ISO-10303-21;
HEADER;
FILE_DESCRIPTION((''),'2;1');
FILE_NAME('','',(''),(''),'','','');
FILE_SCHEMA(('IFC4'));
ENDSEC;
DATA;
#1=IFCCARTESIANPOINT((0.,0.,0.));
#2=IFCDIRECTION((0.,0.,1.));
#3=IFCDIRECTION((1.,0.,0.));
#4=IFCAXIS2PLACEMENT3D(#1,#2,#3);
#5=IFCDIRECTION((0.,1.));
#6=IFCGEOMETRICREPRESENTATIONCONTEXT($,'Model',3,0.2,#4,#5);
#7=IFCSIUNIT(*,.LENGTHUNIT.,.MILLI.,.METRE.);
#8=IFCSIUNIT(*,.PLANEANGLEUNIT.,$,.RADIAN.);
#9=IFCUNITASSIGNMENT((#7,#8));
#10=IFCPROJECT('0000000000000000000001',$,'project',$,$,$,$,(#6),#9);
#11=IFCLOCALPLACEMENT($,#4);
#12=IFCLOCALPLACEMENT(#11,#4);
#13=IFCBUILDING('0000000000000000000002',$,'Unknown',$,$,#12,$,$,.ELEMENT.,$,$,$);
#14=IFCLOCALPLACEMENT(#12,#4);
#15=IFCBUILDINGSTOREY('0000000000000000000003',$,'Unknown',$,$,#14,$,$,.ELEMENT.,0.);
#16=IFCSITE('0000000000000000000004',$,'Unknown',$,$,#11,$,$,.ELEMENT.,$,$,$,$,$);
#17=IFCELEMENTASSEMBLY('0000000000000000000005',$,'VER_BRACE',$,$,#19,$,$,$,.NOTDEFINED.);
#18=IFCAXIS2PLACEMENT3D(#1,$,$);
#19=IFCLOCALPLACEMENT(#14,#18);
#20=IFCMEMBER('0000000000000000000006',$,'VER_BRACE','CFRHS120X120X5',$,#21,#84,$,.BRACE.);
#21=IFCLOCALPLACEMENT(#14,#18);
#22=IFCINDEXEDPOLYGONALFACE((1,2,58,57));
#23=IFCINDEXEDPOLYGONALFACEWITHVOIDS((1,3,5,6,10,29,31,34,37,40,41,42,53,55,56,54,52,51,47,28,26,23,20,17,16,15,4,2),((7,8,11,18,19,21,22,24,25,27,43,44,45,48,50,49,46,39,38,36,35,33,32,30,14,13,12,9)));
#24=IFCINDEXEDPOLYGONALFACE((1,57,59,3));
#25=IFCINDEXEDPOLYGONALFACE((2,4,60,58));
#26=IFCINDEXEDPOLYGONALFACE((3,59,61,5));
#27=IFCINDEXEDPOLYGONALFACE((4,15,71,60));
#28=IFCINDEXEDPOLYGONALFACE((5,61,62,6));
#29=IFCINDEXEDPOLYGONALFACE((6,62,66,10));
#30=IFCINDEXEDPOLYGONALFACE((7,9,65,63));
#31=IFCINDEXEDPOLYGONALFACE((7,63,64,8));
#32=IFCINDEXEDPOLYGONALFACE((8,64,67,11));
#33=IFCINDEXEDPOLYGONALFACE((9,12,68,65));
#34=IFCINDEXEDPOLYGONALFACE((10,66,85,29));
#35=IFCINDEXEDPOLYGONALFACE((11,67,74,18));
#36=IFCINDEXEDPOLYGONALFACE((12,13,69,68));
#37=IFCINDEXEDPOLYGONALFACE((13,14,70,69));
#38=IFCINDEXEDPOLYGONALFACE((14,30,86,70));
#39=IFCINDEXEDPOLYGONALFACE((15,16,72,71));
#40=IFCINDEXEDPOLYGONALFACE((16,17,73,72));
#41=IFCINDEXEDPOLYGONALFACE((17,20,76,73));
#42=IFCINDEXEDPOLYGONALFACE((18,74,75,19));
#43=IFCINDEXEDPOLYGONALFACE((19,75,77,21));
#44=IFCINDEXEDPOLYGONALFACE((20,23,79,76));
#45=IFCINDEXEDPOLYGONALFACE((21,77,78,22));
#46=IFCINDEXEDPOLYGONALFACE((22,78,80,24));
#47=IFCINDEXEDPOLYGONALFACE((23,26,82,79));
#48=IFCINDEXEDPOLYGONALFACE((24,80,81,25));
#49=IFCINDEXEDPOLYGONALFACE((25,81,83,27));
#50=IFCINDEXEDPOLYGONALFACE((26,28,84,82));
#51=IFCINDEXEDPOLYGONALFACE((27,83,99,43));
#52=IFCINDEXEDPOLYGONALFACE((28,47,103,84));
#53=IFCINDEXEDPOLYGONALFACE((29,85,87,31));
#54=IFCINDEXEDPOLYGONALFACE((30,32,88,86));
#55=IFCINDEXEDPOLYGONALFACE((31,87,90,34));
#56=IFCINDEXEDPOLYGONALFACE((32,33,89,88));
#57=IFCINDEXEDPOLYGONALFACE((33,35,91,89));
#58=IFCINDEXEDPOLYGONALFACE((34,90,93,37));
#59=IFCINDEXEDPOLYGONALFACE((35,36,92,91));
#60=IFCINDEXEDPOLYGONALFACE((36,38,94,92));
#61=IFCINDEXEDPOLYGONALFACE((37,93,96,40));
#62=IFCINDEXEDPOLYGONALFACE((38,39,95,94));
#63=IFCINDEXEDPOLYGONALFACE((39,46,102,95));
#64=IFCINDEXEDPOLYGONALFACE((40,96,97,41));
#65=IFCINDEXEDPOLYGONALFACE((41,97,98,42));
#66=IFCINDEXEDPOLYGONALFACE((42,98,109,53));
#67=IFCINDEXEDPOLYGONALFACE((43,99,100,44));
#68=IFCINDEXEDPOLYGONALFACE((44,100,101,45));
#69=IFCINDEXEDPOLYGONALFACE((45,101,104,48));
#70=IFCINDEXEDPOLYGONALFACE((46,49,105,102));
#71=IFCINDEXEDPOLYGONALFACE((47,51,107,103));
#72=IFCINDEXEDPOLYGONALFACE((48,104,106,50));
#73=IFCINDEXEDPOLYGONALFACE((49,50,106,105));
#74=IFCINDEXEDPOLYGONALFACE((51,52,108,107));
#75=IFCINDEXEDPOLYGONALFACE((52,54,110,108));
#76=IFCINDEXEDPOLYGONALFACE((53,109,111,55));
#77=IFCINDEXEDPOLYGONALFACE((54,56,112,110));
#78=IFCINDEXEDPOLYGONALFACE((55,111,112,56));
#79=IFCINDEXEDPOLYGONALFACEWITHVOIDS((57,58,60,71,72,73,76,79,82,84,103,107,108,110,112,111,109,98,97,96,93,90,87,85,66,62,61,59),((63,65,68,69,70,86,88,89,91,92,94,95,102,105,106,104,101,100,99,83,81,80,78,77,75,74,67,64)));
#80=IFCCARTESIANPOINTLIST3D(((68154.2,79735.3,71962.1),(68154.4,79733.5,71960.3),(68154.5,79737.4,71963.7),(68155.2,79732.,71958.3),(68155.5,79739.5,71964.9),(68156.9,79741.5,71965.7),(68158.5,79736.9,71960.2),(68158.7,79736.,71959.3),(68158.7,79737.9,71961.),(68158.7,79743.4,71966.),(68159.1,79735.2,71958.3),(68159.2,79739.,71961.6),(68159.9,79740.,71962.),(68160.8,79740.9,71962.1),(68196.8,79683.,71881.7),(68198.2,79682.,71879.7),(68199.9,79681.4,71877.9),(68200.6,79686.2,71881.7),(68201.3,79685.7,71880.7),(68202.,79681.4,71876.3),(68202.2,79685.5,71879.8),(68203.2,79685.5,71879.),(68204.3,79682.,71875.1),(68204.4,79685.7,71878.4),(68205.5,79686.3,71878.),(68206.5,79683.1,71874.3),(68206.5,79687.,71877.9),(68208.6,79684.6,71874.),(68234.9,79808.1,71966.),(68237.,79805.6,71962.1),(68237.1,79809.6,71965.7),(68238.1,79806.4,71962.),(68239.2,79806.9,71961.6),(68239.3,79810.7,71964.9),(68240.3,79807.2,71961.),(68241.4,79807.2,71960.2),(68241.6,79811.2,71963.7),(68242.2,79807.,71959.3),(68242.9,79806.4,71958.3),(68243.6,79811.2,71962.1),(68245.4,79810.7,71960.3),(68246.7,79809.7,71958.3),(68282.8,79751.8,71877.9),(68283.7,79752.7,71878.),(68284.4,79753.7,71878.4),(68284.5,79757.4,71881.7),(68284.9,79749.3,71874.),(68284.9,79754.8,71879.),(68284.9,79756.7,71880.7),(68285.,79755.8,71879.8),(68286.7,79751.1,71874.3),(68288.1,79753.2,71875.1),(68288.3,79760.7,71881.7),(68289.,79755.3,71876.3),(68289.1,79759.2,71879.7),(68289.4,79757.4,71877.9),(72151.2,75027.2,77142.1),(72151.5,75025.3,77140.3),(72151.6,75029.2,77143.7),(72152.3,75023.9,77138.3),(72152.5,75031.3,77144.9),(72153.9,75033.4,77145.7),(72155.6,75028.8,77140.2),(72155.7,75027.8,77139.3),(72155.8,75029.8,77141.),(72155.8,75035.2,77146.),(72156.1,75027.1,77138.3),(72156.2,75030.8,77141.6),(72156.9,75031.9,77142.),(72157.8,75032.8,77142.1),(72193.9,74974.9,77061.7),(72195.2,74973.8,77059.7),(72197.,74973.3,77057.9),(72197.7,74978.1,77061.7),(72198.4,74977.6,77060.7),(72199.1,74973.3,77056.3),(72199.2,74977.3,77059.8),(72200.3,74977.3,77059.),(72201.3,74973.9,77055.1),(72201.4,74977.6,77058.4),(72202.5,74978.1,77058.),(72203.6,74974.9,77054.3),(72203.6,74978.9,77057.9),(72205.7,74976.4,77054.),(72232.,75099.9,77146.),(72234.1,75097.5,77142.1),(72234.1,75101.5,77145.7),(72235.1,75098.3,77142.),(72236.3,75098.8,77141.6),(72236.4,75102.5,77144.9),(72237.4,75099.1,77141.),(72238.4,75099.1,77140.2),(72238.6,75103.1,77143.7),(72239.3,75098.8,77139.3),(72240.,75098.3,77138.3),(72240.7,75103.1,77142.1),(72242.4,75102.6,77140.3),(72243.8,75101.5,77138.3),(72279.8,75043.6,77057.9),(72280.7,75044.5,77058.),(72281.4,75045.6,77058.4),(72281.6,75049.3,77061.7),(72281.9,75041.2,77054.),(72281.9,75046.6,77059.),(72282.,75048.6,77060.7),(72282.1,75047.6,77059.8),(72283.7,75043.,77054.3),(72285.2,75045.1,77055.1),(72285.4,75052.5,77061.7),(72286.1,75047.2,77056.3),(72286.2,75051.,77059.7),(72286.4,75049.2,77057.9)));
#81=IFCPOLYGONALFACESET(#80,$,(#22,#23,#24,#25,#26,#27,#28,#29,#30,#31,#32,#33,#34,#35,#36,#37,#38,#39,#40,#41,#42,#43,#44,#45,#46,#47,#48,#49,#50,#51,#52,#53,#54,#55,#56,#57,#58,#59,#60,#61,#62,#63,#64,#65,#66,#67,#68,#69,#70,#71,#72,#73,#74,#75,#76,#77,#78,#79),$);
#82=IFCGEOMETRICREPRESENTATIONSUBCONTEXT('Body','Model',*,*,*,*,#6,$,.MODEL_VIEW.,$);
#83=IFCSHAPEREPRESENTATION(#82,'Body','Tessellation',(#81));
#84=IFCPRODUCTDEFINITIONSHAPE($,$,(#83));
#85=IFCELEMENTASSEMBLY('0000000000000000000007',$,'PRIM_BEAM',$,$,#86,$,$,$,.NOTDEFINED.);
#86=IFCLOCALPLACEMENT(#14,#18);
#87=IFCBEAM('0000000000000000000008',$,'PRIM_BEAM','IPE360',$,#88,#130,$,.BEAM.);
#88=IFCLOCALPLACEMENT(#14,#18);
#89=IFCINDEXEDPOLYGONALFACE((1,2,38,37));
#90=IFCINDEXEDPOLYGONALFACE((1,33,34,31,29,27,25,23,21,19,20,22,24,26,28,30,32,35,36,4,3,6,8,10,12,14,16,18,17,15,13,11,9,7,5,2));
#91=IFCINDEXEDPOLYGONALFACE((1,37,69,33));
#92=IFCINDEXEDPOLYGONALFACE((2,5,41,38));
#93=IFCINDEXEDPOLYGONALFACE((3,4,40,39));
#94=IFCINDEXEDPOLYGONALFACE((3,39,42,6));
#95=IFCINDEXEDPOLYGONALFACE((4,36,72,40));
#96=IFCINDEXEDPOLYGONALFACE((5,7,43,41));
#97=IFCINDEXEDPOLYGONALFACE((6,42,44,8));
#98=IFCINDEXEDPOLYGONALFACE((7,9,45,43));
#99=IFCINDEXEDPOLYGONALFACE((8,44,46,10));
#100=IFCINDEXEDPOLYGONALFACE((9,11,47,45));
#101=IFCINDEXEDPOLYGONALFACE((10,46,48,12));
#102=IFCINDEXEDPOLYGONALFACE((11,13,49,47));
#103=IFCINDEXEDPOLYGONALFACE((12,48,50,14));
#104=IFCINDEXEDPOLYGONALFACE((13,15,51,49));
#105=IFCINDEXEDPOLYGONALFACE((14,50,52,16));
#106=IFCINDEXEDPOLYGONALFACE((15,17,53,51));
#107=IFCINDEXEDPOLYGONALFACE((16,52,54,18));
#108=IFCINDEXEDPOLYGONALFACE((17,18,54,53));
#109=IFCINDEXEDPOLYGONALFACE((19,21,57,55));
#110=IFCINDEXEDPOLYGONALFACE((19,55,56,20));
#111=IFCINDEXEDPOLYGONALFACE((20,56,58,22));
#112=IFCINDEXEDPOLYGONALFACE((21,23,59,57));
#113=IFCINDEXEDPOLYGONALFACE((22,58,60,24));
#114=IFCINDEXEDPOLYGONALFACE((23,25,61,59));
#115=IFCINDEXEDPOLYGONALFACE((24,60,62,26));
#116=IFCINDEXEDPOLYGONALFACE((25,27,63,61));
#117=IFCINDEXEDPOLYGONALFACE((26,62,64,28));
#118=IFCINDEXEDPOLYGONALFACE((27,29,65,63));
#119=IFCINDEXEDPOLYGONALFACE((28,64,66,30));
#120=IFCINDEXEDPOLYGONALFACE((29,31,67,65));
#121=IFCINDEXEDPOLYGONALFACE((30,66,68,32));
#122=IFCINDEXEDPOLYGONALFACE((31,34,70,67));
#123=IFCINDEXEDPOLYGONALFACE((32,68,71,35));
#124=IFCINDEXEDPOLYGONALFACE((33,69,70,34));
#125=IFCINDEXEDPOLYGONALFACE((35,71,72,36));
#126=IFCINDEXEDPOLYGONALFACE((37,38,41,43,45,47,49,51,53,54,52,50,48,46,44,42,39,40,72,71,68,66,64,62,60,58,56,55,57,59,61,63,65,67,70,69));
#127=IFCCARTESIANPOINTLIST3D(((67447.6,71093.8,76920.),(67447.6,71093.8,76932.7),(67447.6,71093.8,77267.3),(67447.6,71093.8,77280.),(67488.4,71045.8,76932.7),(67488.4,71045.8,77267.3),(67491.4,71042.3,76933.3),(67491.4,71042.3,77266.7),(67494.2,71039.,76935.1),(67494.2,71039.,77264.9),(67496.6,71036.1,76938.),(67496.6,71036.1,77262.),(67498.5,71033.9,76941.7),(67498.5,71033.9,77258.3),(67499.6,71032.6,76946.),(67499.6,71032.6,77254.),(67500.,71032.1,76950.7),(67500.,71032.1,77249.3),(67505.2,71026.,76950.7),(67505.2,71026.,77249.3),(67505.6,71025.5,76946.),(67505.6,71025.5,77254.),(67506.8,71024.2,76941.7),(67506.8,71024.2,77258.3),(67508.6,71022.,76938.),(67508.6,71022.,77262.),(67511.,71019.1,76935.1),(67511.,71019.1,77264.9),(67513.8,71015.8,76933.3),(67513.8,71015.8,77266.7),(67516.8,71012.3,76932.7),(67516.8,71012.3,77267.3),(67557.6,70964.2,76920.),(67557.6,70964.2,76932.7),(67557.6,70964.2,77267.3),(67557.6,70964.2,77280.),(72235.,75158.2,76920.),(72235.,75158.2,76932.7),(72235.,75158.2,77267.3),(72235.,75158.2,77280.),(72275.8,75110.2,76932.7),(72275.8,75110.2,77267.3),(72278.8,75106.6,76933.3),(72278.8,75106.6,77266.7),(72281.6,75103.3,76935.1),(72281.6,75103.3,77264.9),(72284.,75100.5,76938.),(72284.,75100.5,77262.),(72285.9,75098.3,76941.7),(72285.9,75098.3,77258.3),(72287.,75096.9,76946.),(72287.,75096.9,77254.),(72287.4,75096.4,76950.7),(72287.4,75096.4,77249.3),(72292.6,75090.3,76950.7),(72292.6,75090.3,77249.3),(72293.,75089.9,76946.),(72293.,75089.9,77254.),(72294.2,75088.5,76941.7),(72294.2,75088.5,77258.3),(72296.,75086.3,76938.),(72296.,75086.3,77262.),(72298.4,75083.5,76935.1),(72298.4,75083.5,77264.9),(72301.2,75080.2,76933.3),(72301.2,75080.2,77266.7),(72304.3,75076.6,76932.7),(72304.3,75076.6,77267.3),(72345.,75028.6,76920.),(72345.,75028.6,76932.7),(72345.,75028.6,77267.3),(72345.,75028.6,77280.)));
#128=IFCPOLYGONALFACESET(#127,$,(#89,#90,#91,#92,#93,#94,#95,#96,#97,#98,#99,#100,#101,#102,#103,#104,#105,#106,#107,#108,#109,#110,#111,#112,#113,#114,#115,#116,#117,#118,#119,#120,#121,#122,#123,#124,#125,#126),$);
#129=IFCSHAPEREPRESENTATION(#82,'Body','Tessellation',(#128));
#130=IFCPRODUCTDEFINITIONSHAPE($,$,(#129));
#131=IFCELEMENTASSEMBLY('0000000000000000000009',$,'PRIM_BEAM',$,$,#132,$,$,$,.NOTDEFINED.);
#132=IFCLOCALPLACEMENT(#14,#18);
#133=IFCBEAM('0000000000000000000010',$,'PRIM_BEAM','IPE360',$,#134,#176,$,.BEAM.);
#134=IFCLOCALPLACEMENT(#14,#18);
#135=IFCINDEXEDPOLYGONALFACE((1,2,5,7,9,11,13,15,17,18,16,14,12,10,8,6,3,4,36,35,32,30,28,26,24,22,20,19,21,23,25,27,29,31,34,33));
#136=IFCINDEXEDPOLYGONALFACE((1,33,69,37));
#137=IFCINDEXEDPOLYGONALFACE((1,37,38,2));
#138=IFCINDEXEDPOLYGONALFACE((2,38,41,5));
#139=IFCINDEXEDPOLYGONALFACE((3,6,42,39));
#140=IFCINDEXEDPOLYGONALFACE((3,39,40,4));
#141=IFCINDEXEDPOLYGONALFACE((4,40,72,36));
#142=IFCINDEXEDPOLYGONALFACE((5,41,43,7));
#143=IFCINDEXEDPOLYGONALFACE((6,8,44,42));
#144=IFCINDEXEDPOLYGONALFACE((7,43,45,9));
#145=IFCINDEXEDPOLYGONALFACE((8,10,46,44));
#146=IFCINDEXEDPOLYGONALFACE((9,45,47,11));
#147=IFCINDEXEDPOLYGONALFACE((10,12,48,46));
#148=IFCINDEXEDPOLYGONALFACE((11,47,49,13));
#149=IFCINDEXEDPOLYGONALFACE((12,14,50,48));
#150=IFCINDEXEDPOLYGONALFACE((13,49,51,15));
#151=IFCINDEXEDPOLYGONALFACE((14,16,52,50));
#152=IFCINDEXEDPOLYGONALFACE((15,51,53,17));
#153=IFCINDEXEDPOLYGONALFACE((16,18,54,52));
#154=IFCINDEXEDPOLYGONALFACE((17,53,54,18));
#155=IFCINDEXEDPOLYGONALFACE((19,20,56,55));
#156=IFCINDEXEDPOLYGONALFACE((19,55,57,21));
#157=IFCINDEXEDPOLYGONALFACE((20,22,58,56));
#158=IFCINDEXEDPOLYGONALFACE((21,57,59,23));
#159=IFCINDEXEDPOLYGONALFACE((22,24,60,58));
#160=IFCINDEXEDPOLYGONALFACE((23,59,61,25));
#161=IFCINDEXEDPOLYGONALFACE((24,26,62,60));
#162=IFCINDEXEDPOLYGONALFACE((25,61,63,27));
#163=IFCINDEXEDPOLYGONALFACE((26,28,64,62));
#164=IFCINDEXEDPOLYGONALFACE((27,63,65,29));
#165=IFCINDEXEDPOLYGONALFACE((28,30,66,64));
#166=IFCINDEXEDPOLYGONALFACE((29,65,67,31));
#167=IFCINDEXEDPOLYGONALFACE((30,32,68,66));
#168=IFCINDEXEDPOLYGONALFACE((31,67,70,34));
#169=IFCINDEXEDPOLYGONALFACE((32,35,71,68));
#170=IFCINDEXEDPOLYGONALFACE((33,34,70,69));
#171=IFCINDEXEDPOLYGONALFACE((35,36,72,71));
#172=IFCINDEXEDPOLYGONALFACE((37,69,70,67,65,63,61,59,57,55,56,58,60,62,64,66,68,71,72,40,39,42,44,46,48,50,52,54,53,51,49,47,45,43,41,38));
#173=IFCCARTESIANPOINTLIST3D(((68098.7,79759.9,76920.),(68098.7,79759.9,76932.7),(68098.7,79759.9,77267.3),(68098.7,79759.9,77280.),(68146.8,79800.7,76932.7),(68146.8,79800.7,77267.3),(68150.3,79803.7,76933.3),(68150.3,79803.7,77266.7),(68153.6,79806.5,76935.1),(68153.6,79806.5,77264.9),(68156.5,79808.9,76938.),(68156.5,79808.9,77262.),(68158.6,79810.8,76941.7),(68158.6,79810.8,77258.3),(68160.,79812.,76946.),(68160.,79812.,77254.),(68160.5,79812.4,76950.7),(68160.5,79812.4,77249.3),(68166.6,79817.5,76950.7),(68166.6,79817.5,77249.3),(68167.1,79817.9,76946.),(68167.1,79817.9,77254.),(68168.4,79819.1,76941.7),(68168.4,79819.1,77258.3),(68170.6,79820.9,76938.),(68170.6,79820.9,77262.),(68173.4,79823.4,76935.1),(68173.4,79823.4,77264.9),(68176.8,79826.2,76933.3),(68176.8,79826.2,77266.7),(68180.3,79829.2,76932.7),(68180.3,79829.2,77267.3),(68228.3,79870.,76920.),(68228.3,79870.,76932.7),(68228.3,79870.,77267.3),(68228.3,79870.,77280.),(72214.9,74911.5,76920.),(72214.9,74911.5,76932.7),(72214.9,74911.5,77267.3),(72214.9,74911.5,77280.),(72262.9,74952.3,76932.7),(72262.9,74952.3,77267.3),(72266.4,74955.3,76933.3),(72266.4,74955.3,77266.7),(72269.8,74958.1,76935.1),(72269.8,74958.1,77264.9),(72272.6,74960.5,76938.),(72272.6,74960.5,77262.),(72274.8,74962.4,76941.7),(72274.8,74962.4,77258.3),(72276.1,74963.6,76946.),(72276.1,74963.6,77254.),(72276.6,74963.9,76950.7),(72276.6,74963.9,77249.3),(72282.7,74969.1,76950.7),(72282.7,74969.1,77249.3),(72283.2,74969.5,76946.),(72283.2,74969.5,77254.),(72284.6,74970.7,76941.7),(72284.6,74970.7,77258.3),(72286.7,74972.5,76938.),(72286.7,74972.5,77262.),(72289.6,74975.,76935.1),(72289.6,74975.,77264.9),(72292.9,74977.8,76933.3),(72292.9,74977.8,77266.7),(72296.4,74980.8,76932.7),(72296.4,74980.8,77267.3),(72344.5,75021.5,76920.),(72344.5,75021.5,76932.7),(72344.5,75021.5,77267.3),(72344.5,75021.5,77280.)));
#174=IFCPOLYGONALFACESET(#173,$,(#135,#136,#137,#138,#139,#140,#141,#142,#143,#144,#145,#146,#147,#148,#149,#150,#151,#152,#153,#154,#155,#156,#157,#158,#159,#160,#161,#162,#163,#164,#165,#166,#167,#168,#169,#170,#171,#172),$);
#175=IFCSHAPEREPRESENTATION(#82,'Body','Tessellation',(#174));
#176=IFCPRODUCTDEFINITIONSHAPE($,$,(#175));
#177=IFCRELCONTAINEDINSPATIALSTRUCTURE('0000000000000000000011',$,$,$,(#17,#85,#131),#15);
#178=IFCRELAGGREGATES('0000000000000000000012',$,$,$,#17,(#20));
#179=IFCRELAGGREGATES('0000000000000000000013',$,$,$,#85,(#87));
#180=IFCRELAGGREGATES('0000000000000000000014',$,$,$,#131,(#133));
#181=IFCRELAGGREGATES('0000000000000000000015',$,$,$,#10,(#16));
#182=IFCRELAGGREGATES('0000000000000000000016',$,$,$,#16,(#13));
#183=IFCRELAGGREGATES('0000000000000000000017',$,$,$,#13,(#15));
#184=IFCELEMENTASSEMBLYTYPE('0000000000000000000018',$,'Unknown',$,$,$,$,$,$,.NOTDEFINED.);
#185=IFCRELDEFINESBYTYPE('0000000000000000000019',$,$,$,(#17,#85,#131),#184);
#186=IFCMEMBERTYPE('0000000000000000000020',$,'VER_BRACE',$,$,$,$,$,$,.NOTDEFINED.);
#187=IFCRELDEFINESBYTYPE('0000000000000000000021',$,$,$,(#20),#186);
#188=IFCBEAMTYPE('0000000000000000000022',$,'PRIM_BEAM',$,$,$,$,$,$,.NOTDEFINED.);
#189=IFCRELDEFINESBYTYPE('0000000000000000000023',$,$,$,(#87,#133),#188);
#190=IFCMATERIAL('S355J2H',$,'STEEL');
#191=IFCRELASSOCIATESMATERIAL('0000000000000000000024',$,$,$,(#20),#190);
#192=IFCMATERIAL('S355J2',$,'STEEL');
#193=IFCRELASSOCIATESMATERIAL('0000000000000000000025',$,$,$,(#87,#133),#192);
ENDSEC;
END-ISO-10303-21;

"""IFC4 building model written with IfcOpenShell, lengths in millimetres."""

from ifc_helpers import new_model, si_unit, direction, frame, origin_with_axes, origin_2d_with_axis, place, context, subcontext, project, spatial, hollow_rectangle, i_section, extrude, material, material_profile, profile_set, profile_usage, type_object, element, aggregate, save


model = new_model("IFC4")

# Units and contexts
model_context = context("Model", 3, precision=0.2, world=origin_with_axes(), true_north=direction((0.0, 1.0)))
body_context = subcontext(model_context, "Body", "Model", "MODEL_VIEW")
ifc_project = project(units=[si_unit("LENGTHUNIT", "METRE", prefix="MILLI"), si_unit("PLANEANGLEUNIT", "RADIAN")], contexts=[model_context])

# Site, building, storey
site_placement = place(None, origin_with_axes())
site = spatial("IfcSite", under=ifc_project, at=site_placement, Name="Unknown", CompositionType="ELEMENT")
building_placement = place(site_placement, origin_with_axes())
building = spatial("IfcBuilding", under=site, at=building_placement, Name="Unknown", CompositionType="ELEMENT")
storey_placement = place(building_placement, origin_with_axes())
storey = spatial("IfcBuildingStorey", under=building, at=storey_placement, Name="Unknown", CompositionType="ELEMENT", Elevation=0.0)

# Shared definitions
element_assembly_type = type_object("IfcElementAssemblyType", Name="Unknown", PredefinedType="NOTDEFINED")
ifc_material_1 = material(Name="S355J2", Category="STEEL")

# Element assembly, member
assembly_1_placement = place(storey_placement, frame((72218.8, 75038.2, 77100.0), z_axis=(0.762329, 0.64719, 0.0), x_axis=(-0.495866, 0.584084, -0.642622)))
assembly_1 = element("IfcElementAssembly", 1, at=assembly_1_placement, inside=storey, type_object=element_assembly_type, Name="VER_BRACE", PredefinedType="NOTDEFINED")
ifc_material_2 = material(Name="S355J2H", Category="STEEL")
ifc_material_profile_1 = material_profile(ifc_material_2, hollow_rectangle(XDim=120.0, YDim=120.0, WallThickness=5.0, InnerFilletRadius=5.0, OuterFilletRadius=10.0, at=origin_2d_with_axis()), Name="CFRHS120X120X5")
ifc_profile_set_1 = profile_set([ifc_material_profile_1])
ifc_profile_usage_1 = profile_usage(ifc_profile_set_1, cardinal=5)
member_type = type_object("IfcMemberType", Name="VER_BRACE")
member_placement = place(assembly_1_placement, origin_with_axes())
member = element("IfcMember", 2, at=member_placement, type_object=member_type, material=ifc_profile_usage_1, Name="VER_BRACE", Description="CFRHS120X120X5", PredefinedType="BRACE", context=body_context, shape_type="SolidModel", body=[
    extrude(hollow_rectangle(XDim=120.0, YDim=120.0, WallThickness=5.0, InnerFilletRadius=5.0, OuterFilletRadius=10.0, at=origin_2d_with_axis()), frame((0.0, 0.0, 0.0), z_axis=(-1.0, 0.0, 0.0), x_axis=(0.0, 0.0, 1.0)), (0.0, 0.0, -1.0), 8060.7),
])
aggregate(assembly_1, [member])

# Element assemblies, beams
assembly_2_placement = place(storey_placement, frame((67502.6, 71029.0, 77100.0), z_axis=(0.64719, -0.762329, 0.0), x_axis=(0.762329, 0.64719, 0.0)))
assembly_2 = element("IfcElementAssembly", 3, at=assembly_2_placement, inside=storey, type_object=element_assembly_type, Name="PRIM_BEAM", PredefinedType="NOTDEFINED")
ifc_material_profile_2 = material_profile(ifc_material_1, i_section(OverallWidth=170.0, OverallDepth=360.0, WebThickness=8.0, FlangeThickness=12.7, FilletRadius=18.0, FlangeEdgeRadius=0.0, FlangeSlope=0.0, at=origin_2d_with_axis()), Name="IPE360")
ifc_profile_set_2 = profile_set([ifc_material_profile_2])
ifc_profile_usage_2 = profile_usage(ifc_profile_set_2, cardinal=2)
beam_type_1 = type_object("IfcBeamType", Name="PRIM_BEAM")
beam_1_placement = place(assembly_2_placement, origin_with_axes())
beam_1 = element("IfcBeam", 4, at=beam_1_placement, type_object=beam_type_1, material=ifc_profile_usage_2, Name="PRIM_BEAM", Description="IPE360", PredefinedType="BEAM", context=body_context, shape_type="SolidModel", body=[
    extrude(i_section(OverallWidth=170.0, OverallDepth=360.0, WebThickness=8.0, FlangeThickness=12.7, FilletRadius=18.0, FlangeEdgeRadius=0.0, FlangeSlope=0.0, at=origin_2d_with_axis()), frame((0.0, 0.0, 0.0), z_axis=(-1.0, 0.0, 0.0), x_axis=(0.0, 0.0, 1.0)), (0.0, 0.0, -1.0), 6280.0),
])
aggregate(assembly_2, [beam_1])
assembly_3_placement = place(storey_placement, frame((68163.5, 79814.9, 77100.0), z_axis=(-0.762329, -0.64719, 0.0), x_axis=(0.64719, -0.762329, 0.0)))
assembly_3 = element("IfcElementAssembly", 5, at=assembly_3_placement, inside=storey, type_object=element_assembly_type, Name="PRIM_BEAM", PredefinedType="NOTDEFINED")
beam_2_placement = place(assembly_3_placement, origin_with_axes())
beam_2 = element("IfcBeam", 6, at=beam_2_placement, type_object=beam_type_1, material=ifc_profile_usage_2, Name="PRIM_BEAM", Description="IPE360", PredefinedType="BEAM", context=body_context, shape_type="SolidModel", body=[
    extrude(i_section(OverallWidth=170.0, OverallDepth=360.0, WebThickness=8.0, FlangeThickness=12.7, FilletRadius=18.0, FlangeEdgeRadius=0.0, FlangeSlope=0.0, at=origin_2d_with_axis()), frame((0.0, 0.0, 0.0), z_axis=(-1.0, 0.0, 0.0), x_axis=(0.0, 0.0, 1.0)), (0.0, 0.0, -1.0), 6360.0),
])
aggregate(assembly_3, [beam_2])

save(model, "model.ifc")
